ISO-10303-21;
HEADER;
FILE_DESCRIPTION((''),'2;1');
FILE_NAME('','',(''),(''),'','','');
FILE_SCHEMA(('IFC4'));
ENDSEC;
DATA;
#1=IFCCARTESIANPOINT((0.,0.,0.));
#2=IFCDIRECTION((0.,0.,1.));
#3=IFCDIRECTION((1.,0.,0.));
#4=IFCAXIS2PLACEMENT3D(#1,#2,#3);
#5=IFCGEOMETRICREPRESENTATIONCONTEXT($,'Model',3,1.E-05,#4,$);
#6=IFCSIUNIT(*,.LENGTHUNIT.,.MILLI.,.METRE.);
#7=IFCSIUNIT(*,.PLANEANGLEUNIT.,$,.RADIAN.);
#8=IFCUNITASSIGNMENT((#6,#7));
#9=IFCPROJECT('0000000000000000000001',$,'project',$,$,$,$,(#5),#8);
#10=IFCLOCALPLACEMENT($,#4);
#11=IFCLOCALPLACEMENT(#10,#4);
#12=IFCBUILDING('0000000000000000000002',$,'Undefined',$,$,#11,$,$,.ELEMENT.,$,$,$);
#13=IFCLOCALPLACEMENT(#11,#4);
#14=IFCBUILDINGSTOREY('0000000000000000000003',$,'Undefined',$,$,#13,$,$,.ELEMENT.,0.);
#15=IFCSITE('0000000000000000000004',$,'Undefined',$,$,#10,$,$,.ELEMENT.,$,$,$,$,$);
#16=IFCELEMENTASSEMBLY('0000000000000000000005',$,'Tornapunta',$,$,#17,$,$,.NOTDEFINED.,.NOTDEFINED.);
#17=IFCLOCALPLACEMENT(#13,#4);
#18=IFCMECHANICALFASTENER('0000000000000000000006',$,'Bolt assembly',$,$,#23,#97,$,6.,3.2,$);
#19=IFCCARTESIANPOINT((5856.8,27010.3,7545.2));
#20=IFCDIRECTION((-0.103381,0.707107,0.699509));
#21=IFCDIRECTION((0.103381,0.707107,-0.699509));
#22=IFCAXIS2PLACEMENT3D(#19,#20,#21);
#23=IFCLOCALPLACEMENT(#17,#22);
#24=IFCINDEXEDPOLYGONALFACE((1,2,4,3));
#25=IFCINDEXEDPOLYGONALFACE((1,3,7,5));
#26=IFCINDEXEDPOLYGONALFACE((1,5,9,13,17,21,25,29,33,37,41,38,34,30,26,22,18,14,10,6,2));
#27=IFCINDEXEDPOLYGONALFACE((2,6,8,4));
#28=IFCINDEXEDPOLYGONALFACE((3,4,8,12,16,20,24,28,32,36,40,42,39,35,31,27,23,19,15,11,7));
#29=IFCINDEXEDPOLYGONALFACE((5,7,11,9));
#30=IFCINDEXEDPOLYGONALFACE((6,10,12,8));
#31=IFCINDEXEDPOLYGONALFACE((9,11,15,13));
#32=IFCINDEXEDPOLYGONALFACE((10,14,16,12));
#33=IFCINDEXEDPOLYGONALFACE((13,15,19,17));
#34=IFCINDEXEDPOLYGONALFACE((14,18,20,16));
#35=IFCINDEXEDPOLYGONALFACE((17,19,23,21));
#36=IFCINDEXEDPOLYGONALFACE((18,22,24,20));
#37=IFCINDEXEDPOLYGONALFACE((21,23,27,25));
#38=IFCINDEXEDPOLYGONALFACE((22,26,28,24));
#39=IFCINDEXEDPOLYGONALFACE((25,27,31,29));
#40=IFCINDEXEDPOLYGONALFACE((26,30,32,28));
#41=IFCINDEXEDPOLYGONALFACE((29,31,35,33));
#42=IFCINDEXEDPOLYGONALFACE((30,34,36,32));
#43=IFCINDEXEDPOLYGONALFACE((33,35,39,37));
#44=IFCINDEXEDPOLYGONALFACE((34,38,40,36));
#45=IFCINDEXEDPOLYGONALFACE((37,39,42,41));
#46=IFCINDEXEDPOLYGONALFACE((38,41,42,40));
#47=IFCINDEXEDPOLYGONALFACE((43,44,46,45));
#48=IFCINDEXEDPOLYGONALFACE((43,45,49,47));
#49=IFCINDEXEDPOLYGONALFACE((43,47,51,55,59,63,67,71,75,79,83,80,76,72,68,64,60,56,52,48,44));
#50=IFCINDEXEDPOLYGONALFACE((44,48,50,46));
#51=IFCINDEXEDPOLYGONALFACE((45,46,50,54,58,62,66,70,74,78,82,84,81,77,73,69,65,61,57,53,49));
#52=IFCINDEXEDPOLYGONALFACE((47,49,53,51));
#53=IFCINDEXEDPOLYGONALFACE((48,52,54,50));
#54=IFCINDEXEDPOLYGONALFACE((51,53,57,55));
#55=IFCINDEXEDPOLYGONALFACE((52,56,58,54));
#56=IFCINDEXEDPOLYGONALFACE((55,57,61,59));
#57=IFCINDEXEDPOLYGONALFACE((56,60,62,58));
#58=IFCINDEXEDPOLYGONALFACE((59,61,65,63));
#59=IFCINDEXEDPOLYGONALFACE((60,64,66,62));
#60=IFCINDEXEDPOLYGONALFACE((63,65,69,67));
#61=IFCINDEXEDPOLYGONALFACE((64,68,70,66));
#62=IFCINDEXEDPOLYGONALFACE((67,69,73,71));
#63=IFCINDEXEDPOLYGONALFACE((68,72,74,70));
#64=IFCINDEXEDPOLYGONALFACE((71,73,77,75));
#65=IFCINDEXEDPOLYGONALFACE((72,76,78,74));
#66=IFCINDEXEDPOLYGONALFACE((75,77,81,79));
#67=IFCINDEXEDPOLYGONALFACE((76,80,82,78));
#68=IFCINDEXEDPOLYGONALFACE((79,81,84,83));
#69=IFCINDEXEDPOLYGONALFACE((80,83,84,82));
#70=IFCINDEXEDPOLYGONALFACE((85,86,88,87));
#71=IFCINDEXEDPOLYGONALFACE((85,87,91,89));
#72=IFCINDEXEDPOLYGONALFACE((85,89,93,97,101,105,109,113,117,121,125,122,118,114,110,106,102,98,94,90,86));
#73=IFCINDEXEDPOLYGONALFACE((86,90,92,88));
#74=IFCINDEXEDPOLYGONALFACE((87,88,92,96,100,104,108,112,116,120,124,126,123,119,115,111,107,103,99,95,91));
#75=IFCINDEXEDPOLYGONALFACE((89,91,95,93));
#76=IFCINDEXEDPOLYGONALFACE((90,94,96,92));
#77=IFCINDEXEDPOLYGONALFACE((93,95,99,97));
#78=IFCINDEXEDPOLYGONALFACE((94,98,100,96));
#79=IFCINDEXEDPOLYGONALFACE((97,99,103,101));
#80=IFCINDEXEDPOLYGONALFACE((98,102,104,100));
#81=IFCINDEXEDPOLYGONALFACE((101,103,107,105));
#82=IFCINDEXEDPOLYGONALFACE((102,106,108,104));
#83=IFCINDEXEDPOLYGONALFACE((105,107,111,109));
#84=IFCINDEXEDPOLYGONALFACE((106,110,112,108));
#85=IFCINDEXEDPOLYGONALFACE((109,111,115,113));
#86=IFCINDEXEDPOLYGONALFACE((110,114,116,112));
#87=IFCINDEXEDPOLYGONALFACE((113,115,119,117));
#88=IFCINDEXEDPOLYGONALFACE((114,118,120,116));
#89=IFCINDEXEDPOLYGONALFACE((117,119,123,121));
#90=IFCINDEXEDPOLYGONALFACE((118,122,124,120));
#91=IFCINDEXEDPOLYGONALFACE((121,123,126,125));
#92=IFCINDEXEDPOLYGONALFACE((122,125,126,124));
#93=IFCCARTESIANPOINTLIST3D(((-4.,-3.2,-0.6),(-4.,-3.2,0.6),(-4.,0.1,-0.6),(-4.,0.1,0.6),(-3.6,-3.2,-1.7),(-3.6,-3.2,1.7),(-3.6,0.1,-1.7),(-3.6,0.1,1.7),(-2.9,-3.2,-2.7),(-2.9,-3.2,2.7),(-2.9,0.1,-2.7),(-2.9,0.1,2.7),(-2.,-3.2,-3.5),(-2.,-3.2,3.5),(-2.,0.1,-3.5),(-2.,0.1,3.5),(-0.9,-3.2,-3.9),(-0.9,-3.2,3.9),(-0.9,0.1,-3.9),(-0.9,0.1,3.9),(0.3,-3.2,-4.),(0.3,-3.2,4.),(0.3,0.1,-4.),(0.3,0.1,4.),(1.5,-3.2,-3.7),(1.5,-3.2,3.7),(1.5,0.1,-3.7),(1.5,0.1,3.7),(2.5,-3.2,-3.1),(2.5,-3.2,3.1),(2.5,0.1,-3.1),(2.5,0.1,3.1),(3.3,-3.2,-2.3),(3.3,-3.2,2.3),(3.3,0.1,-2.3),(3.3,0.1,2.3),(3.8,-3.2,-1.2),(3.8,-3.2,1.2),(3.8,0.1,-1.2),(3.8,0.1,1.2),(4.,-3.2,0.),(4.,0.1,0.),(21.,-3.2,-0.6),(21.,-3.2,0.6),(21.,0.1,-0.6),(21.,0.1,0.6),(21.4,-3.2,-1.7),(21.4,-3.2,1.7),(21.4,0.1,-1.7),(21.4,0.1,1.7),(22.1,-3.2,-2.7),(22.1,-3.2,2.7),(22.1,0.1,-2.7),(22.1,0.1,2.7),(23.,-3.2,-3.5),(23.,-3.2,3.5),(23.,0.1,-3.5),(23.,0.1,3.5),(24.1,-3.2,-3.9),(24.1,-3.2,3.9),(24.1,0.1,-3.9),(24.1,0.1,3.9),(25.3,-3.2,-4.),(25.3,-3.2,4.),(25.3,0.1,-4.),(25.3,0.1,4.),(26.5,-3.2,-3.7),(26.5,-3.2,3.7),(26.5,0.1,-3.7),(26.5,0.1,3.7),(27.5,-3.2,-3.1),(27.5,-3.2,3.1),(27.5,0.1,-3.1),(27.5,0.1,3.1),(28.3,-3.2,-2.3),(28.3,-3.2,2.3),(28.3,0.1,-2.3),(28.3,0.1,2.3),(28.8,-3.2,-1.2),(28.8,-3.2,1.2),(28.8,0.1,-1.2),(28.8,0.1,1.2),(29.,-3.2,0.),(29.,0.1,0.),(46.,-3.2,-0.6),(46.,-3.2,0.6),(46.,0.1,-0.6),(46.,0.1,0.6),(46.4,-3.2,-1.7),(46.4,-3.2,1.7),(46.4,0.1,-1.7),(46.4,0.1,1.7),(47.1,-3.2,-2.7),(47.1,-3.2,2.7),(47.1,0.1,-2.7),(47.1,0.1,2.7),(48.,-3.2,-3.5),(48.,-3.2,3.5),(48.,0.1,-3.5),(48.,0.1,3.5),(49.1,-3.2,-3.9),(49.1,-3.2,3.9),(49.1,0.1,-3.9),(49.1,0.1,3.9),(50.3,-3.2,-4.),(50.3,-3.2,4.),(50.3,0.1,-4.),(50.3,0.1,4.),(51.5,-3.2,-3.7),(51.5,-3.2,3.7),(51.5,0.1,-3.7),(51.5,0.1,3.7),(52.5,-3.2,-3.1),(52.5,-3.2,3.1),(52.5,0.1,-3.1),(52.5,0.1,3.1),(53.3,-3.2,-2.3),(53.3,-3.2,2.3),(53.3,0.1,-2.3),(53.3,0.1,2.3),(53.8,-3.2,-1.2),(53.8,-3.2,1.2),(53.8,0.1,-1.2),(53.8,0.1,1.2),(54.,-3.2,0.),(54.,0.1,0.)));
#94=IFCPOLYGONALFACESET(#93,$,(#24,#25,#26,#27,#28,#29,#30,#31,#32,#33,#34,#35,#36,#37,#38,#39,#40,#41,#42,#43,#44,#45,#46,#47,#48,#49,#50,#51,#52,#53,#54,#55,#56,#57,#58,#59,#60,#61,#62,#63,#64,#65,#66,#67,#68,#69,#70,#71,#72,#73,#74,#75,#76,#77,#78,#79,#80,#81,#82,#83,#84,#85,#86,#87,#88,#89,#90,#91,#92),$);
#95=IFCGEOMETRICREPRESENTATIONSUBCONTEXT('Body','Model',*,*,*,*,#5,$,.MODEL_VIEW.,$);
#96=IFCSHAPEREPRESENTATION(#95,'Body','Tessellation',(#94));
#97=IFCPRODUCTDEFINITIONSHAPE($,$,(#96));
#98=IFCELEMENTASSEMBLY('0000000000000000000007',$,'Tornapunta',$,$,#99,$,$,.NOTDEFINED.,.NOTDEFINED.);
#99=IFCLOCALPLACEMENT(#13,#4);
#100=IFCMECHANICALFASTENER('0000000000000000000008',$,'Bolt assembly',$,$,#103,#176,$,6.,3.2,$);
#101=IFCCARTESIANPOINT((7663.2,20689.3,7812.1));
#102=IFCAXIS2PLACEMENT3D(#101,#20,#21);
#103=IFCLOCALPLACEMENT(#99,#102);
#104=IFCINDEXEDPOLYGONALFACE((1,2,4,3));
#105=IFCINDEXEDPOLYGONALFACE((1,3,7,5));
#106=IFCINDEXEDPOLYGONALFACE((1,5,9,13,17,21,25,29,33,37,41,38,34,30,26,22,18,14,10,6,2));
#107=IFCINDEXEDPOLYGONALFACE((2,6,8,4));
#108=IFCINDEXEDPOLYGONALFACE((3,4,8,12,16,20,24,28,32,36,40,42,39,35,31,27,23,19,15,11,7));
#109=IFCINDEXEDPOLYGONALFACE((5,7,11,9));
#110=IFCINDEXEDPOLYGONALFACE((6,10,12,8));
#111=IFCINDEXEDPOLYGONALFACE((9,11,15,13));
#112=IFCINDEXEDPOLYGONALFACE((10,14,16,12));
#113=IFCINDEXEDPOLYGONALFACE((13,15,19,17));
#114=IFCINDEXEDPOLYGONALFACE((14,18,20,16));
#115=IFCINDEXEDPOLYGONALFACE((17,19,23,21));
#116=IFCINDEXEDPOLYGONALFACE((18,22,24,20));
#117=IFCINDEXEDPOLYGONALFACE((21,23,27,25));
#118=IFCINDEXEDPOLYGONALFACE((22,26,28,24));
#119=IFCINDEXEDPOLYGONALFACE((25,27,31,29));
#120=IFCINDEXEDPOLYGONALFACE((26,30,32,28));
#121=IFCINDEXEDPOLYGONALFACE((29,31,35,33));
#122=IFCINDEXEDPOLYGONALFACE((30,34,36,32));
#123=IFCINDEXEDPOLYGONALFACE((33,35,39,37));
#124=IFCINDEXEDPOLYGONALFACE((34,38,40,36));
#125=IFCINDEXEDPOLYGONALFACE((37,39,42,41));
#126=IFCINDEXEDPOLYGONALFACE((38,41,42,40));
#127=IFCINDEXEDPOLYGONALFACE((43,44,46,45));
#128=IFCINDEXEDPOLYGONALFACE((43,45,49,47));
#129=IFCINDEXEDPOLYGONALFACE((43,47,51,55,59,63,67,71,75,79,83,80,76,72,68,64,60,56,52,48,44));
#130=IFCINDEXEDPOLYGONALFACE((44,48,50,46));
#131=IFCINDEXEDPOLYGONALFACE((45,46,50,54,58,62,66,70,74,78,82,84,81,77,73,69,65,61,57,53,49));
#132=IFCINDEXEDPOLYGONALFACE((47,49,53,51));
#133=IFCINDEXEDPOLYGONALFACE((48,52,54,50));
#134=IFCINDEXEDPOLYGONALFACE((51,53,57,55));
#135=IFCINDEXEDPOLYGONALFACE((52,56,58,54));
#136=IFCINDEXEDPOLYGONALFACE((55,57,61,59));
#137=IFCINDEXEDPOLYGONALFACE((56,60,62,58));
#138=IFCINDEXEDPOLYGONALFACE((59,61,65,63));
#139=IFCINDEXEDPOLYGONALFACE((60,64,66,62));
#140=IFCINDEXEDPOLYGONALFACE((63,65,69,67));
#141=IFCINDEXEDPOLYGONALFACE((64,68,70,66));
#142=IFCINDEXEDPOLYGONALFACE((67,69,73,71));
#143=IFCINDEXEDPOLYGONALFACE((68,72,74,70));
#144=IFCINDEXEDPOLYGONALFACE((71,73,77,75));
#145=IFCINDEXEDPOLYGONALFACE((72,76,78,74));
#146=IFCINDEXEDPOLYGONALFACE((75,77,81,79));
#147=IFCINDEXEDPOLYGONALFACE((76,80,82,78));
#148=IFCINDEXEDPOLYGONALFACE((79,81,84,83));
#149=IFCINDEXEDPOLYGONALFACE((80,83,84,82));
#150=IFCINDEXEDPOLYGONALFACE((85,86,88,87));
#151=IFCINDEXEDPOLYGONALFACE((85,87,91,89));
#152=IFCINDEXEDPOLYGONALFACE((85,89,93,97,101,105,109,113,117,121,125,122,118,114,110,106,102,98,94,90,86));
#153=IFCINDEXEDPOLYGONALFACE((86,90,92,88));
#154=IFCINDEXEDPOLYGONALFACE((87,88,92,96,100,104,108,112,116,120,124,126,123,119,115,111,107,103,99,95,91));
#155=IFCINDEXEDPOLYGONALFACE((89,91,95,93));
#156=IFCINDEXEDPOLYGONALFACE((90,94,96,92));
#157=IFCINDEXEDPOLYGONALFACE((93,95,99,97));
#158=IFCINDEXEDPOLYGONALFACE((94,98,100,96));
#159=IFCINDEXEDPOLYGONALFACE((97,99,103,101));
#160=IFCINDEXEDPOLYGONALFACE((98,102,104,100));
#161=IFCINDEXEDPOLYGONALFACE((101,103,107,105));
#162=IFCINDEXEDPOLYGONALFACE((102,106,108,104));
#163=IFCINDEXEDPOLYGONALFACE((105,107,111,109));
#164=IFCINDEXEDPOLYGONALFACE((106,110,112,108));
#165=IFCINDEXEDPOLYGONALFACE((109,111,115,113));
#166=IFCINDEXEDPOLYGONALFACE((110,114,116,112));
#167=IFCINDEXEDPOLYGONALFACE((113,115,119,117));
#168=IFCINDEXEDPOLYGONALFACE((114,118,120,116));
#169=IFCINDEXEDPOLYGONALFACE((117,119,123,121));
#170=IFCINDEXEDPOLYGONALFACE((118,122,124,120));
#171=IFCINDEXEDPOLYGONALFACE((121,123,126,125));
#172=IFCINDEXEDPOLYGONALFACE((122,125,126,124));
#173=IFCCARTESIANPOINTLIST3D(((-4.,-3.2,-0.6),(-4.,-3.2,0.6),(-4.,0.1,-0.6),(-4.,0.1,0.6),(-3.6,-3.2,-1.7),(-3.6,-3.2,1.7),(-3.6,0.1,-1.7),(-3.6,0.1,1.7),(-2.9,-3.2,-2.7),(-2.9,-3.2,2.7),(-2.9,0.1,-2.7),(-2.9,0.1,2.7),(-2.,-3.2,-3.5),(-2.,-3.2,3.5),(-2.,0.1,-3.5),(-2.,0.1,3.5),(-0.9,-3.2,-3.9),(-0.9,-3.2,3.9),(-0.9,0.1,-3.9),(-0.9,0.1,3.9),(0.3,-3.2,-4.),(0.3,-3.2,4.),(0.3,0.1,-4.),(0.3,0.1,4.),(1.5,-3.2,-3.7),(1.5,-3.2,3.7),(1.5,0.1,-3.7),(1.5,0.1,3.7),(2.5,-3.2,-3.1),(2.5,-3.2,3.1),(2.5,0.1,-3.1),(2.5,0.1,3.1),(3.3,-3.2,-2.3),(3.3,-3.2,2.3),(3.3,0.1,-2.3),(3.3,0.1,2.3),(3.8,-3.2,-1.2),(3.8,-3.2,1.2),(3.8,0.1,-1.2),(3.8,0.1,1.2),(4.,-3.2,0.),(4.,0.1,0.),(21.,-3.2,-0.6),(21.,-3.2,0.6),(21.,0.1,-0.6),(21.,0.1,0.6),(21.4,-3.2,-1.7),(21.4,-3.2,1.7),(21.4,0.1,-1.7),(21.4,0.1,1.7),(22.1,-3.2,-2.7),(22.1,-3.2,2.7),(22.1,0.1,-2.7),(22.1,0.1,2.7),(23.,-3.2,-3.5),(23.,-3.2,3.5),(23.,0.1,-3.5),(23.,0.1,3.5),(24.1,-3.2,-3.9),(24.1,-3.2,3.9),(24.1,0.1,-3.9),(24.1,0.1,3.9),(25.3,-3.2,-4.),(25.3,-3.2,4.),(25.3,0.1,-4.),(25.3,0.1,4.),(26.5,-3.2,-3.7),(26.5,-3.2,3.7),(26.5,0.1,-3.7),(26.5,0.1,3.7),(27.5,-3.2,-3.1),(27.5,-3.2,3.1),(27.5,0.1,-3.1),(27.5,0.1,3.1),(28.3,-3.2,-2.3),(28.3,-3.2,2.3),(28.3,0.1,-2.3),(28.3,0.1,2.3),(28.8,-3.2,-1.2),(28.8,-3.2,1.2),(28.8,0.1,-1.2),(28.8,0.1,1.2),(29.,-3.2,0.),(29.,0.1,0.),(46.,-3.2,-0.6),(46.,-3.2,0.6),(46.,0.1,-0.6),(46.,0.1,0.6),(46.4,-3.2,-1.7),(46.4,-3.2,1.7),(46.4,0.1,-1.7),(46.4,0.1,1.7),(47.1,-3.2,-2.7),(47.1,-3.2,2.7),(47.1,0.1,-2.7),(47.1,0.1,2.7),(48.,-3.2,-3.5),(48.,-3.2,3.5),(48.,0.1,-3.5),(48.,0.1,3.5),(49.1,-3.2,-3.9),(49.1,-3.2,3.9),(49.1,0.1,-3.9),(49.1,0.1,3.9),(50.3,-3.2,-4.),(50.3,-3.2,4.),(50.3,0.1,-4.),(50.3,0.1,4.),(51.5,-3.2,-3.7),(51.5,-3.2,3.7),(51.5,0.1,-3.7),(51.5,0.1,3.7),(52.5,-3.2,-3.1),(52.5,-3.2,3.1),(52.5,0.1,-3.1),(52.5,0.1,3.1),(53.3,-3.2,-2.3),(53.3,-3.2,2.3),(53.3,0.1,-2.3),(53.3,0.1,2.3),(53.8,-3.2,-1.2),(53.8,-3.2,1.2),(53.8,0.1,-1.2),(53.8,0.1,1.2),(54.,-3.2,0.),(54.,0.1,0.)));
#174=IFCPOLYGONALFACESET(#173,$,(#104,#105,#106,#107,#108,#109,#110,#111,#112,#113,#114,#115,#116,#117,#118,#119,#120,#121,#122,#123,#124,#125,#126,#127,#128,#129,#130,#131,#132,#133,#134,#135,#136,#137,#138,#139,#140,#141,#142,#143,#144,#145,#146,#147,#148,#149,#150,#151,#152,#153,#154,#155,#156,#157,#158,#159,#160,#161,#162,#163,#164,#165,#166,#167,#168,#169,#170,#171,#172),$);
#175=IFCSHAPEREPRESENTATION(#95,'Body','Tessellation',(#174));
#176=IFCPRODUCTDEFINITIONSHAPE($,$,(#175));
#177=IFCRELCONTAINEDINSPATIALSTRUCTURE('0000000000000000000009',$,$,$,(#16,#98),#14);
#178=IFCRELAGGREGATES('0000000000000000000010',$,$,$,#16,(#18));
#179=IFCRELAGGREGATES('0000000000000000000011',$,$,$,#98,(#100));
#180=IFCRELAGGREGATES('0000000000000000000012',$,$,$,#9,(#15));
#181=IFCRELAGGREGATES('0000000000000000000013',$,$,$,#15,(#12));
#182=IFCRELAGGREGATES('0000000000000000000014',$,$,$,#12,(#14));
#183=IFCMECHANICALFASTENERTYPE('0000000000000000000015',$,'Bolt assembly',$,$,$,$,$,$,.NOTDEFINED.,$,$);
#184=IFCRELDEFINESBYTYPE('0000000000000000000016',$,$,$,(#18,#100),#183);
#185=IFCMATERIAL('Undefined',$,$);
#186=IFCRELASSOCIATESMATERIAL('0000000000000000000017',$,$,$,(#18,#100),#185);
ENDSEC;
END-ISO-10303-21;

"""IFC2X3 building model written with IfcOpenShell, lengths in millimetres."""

from ifc_helpers import new_model, si_unit, frame, origin_with_axes, origin_2d_with_axis, place, context, subcontext, project, spatial, circle, extrude, source, transform, mapped, material, type_object, element, aggregate, save


model = new_model("IFC2X3")

# Units and contexts
model_context = context("Model", 3, precision=1e-05, world=origin_with_axes())
body_context = subcontext(model_context, "Body", "Model", "MODEL_VIEW")
ifc_project = project(units=[si_unit("LENGTHUNIT", "METRE", prefix="MILLI"), si_unit("PLANEANGLEUNIT", "RADIAN")], contexts=[model_context])

# Site, building, storey
site_placement = place(None, origin_with_axes())
site = spatial("IfcSite", under=ifc_project, at=site_placement, Name="Undefined", CompositionType="ELEMENT")
building_placement = place(site_placement, origin_with_axes())
building = spatial("IfcBuilding", under=site, at=building_placement, Name="Undefined", CompositionType="ELEMENT")
storey_placement = place(building_placement, origin_with_axes())
storey = spatial("IfcBuildingStorey", under=building, at=storey_placement, Name="Undefined", CompositionType="ELEMENT", Elevation=0.0)

# Shared definitions
ifc_material_1 = material(Name="Undefined")
mechanical_fastener_type = type_object("IfcMechanicalFastenerType", Name="Bolt assembly")

# Element assemblies, mechanical fasteners
shared_shape_1 = source(origin_with_axes(), body_context, "Body", "SweptSolid", [
    extrude(circle(Radius=4.0, at=origin_2d_with_axis()), frame((0.0, -3.2, 0.0), z_axis=(0.0, 1.0, 0.0), x_axis=(1.0, 0.0, 0.0)), (0.0, 0.0, 1.0), 3.3),
])
assembly_1_placement = place(storey_placement, origin_with_axes())
assembly_1 = element("IfcElementAssembly", 1, at=assembly_1_placement, inside=storey, Name="Tornapunta", AssemblyPlace="NOTDEFINED", PredefinedType="NOTDEFINED")
mechanical_fastener_1_placement = place(assembly_1_placement, frame((5856.8, 27010.3, 7545.2), z_axis=(-0.103381, 0.707107, 0.699509), x_axis=(0.103381, 0.707107, -0.699509)))
mechanical_fastener_1 = element("IfcMechanicalFastener", 2, at=mechanical_fastener_1_placement, type_object=mechanical_fastener_type, material=ifc_material_1, Name="Bolt assembly", NominalDiameter=6.0, NominalLength=3.2, context=body_context, shape_type="MappedRepresentation", body=[
    mapped(shared_shape_1, transform((0.0, 0.0, 0.0))),
    mapped(shared_shape_1, transform((25.0, 0.0, 0.0))),
    mapped(shared_shape_1, transform((50.0, 0.0, 0.0))),
])
aggregate(assembly_1, [mechanical_fastener_1])
assembly_2_placement = place(storey_placement, origin_with_axes())
assembly_2 = element("IfcElementAssembly", 3, at=assembly_2_placement, inside=storey, Name="Tornapunta", AssemblyPlace="NOTDEFINED", PredefinedType="NOTDEFINED")
mechanical_fastener_2_placement = place(assembly_2_placement, frame((7663.2, 20689.3, 7812.1), z_axis=(-0.103381, 0.707107, 0.699509), x_axis=(0.103381, 0.707107, -0.699509)))
mechanical_fastener_2 = element("IfcMechanicalFastener", 4, at=mechanical_fastener_2_placement, type_object=mechanical_fastener_type, material=ifc_material_1, Name="Bolt assembly", NominalDiameter=6.0, NominalLength=3.2, context=body_context, shape_type="MappedRepresentation", body=[
    mapped(shared_shape_1, transform((0.0, 0.0, 0.0))),
    mapped(shared_shape_1, transform((25.0, 0.0, 0.0))),
    mapped(shared_shape_1, transform((50.0, 0.0, 0.0))),
])
aggregate(assembly_2, [mechanical_fastener_2])

save(model, "model.ifc")
